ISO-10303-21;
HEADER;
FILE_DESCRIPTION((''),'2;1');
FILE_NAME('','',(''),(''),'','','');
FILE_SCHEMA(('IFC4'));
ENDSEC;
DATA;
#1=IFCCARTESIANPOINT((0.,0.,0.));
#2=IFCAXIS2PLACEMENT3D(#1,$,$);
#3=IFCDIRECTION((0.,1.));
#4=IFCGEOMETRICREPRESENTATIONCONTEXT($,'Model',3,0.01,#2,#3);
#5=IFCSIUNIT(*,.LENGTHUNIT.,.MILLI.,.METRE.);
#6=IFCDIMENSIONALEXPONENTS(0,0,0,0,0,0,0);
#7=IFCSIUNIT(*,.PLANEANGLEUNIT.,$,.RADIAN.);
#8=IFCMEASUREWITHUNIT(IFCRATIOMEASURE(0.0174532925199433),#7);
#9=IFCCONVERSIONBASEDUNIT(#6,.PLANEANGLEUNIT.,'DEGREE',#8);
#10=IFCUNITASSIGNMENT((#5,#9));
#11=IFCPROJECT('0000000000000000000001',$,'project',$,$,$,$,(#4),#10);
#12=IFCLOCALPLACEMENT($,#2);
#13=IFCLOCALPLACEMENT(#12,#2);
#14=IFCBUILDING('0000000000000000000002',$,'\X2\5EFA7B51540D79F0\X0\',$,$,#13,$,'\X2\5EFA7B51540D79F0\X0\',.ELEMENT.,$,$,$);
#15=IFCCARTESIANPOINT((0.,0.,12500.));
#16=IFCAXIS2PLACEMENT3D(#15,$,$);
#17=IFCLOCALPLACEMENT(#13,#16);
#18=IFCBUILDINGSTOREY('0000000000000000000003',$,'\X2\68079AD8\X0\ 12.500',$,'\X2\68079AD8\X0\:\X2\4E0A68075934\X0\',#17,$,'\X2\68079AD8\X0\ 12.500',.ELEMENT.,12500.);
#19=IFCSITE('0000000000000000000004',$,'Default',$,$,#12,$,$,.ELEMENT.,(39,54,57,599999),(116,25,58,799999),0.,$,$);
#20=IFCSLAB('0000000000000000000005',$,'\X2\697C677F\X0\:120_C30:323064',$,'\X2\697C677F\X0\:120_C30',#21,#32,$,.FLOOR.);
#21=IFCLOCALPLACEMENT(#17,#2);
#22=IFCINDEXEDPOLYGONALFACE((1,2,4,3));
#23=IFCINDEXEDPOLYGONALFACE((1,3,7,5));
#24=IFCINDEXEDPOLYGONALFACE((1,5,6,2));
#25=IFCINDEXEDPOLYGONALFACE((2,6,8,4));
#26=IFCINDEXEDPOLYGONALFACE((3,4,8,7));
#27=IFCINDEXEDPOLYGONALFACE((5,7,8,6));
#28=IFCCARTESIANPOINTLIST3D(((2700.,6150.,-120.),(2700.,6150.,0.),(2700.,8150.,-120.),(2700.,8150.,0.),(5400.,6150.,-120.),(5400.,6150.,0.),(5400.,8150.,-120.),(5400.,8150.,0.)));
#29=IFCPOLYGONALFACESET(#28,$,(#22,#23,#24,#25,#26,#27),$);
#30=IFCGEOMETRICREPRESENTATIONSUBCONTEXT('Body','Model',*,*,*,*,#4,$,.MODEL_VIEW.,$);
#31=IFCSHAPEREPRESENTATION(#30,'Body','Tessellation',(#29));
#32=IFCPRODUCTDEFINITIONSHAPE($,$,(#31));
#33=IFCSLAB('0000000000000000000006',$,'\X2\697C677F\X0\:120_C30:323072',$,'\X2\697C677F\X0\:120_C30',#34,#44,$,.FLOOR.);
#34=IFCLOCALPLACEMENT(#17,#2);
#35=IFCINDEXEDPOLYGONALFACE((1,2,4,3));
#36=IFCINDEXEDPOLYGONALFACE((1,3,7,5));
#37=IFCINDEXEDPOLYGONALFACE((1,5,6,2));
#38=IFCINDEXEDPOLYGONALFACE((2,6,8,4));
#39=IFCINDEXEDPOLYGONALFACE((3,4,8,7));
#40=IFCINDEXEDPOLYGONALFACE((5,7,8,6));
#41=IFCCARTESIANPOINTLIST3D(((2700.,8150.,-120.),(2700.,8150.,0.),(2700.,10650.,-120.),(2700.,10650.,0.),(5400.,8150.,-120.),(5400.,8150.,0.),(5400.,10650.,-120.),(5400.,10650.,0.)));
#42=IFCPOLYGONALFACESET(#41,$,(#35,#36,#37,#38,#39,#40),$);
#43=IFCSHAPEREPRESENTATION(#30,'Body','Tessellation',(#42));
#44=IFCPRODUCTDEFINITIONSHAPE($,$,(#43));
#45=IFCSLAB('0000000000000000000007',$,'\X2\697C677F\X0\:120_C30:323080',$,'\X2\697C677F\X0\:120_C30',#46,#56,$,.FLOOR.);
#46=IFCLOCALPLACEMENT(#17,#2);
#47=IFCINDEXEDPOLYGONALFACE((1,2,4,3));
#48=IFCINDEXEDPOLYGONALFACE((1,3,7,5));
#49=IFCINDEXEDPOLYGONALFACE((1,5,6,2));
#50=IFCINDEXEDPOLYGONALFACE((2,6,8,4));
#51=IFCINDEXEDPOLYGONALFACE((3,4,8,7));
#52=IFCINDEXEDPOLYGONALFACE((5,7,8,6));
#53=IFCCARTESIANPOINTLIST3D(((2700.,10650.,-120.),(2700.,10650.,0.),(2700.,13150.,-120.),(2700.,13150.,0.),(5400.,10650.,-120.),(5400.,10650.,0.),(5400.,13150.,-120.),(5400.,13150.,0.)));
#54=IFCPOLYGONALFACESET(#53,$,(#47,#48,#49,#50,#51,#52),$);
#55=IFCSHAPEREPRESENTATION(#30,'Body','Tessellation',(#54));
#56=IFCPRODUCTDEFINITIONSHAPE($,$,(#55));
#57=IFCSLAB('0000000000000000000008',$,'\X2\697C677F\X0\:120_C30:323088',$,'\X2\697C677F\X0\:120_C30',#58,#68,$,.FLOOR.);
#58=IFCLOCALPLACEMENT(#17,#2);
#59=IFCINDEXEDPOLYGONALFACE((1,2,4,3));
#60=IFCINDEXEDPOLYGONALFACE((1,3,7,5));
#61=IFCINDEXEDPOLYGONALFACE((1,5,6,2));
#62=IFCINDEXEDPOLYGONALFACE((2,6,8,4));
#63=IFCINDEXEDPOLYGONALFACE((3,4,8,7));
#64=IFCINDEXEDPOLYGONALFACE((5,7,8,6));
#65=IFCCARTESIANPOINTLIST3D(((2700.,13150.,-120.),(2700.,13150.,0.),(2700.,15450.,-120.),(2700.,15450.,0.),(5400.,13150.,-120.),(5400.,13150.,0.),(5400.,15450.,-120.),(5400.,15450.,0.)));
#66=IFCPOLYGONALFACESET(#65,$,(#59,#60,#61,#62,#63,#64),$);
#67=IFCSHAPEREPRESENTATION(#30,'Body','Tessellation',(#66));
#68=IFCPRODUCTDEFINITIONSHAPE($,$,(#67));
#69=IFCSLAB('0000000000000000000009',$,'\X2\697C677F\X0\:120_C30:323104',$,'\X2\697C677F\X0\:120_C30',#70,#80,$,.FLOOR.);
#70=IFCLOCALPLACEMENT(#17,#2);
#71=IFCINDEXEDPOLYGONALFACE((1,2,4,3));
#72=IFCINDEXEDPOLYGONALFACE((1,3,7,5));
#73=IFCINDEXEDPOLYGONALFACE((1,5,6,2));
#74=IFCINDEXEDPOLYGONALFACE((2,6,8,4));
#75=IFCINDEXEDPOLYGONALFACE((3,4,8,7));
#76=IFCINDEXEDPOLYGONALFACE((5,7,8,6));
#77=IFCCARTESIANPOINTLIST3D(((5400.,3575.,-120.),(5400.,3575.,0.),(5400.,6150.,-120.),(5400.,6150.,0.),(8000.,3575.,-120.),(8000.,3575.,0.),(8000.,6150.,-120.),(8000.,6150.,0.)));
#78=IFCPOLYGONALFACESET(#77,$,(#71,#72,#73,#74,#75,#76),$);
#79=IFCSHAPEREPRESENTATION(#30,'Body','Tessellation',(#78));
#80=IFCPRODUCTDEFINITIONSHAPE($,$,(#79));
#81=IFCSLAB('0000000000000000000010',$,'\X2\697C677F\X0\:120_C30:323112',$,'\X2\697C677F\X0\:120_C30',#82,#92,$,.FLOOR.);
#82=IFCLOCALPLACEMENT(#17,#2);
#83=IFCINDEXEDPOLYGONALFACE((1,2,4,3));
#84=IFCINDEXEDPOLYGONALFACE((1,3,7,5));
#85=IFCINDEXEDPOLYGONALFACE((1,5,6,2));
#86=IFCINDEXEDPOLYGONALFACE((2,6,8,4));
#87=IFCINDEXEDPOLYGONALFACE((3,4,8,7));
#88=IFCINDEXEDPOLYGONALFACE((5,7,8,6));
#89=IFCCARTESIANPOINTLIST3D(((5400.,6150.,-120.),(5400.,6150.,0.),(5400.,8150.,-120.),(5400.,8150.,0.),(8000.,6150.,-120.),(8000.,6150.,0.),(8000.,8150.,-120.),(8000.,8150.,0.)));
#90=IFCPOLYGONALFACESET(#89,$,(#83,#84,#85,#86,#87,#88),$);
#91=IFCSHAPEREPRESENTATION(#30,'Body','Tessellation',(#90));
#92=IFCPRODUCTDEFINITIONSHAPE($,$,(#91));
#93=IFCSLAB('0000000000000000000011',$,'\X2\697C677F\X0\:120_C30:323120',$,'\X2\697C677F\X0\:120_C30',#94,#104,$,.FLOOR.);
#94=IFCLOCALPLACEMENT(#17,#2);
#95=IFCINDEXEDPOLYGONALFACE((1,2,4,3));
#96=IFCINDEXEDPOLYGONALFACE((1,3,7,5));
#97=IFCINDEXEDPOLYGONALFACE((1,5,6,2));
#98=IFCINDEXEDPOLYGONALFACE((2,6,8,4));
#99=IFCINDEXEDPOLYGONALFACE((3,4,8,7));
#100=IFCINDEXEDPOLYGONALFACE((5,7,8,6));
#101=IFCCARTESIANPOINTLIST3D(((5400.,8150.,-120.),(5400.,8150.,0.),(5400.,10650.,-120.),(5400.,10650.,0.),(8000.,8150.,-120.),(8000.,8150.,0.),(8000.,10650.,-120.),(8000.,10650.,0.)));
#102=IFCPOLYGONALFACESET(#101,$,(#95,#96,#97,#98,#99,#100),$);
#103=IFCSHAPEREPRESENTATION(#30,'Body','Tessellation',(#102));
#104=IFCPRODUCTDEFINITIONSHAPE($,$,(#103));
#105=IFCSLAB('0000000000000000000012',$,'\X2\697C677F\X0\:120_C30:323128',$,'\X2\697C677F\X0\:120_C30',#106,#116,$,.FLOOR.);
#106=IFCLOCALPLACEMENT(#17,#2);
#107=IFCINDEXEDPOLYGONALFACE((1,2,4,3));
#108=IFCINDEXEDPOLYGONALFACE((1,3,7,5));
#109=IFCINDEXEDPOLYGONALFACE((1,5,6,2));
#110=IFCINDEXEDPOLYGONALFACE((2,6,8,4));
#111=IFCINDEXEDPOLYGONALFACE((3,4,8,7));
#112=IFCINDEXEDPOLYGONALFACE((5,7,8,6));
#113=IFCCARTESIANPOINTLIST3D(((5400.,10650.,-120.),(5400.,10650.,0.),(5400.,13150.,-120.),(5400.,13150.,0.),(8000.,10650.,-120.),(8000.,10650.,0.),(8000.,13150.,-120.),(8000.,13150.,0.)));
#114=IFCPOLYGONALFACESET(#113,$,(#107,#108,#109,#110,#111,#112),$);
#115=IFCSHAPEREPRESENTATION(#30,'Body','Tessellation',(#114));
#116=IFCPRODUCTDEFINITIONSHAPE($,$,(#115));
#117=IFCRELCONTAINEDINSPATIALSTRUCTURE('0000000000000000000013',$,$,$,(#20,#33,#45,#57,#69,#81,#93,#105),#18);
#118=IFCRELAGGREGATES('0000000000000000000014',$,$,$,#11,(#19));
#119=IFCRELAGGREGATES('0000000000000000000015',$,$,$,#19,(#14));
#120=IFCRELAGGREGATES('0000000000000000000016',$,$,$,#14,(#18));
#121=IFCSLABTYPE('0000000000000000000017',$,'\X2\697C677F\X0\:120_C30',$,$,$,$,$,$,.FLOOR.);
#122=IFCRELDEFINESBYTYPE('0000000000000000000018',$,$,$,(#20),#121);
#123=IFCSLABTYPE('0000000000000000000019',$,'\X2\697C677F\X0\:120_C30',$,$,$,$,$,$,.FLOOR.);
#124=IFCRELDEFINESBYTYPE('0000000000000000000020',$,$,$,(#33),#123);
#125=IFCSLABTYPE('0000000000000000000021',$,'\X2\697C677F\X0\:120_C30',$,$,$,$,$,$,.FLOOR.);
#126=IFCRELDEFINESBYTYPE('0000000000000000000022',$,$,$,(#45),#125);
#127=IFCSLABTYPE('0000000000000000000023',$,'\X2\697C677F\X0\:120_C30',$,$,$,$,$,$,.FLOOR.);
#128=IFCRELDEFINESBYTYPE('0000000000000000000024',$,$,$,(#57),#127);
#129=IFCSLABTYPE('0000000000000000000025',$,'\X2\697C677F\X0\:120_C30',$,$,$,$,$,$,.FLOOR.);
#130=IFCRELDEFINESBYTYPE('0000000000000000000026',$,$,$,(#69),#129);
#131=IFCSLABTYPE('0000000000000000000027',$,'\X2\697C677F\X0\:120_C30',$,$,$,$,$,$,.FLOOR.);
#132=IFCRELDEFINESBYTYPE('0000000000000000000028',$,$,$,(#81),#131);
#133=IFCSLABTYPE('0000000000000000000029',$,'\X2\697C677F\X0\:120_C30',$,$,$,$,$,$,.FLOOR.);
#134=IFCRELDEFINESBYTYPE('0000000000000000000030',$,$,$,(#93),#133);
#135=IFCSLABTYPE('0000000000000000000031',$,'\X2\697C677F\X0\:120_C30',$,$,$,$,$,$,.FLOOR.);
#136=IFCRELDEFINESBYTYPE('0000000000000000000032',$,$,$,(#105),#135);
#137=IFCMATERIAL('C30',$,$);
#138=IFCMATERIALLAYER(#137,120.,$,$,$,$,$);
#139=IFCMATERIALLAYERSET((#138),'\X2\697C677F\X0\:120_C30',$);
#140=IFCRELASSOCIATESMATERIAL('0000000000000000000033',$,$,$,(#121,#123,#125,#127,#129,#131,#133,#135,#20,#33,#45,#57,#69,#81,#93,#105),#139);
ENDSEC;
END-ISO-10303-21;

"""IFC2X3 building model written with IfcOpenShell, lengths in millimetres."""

from ifc_helpers import new_model, entity, si_unit, converted_unit, direction, frame, frame_2d, origin, origin_2d_with_axis, place, context, subcontext, project, spatial, rectangle, extrude, material, layer, layer_set, layer_usage, type_object, element, save


model = new_model("IFC2X3")

# Units and contexts
model_context = context("Model", 3, precision=0.01, world=origin(), true_north=direction((0.0, 1.0)))
body_context = subcontext(model_context, "Body", "Model", "MODEL_VIEW")
ifc_project = project(units=[si_unit("LENGTHUNIT", "METRE", prefix="MILLI"), converted_unit("PLANEANGLEUNIT", "DEGREE", entity("IfcRatioMeasure", 0.0174532925199433), si_unit("PLANEANGLEUNIT", "RADIAN"), dimensions=[0, 0, 0, 0, 0, 0, 0])], contexts=[model_context])

# Site, building, storey
site_placement = place(None, origin())
site = spatial("IfcSite", under=ifc_project, at=site_placement, Name="Default", CompositionType="ELEMENT", RefLatitude=(39, 54, 57, 599999), RefLongitude=(116, 25, 58, 799999), RefElevation=0.0)
building_placement = place(site_placement, origin())
building = spatial("IfcBuilding", under=site, at=building_placement, Name="建筑名称", LongName="建筑名称", CompositionType="ELEMENT")
storey_placement = place(building_placement, frame((0.0, 0.0, 12500.0)))
storey = spatial("IfcBuildingStorey", under=building, at=storey_placement, Name="标高 12.500", ObjectType="标高:上标头", LongName="标高 12.500", CompositionType="ELEMENT", Elevation=12500.0)

# Shared definitions
ifc_material = material(Name="C30")

# Slabs
ifc_layer = layer(ifc_material, 120.0)
ifc_layer_set = layer_set([ifc_layer], Name="楼板:120_C30")
ifc_layer_usage_1 = layer_usage(ifc_layer_set, "AXIS3", "POSITIVE", 0.0)
slab_type_1 = type_object("IfcSlabType", Name="楼板:120_C30", PredefinedType="FLOOR", material=ifc_layer_set)
slab_1_placement = place(storey_placement, origin())
element("IfcSlab", 1, at=slab_1_placement, inside=storey, type_object=slab_type_1, material=ifc_layer_usage_1, Name="楼板:120_C30:323064", ObjectType="楼板:120_C30", PredefinedType="FLOOR", context=body_context, shape_type="SweptSolid", body=[
    extrude(rectangle(XDim=2000.0, YDim=2700.0, at=origin_2d_with_axis()), frame((4050.0, 7150.0, 0.0), z_axis=(0.0, 0.0, -1.0), x_axis=(0.0, 1.0, 0.0)), (0.0, 0.0, 1.0), 120.0),
])
ifc_layer_usage_2 = layer_usage(ifc_layer_set, "AXIS3", "POSITIVE", 0.0)
slab_type_2 = type_object("IfcSlabType", Name="楼板:120_C30", PredefinedType="FLOOR", material=ifc_layer_set)
slab_2_placement = place(storey_placement, origin())
element("IfcSlab", 2, at=slab_2_placement, inside=storey, type_object=slab_type_2, material=ifc_layer_usage_2, Name="楼板:120_C30:323072", ObjectType="楼板:120_C30", PredefinedType="FLOOR", context=body_context, shape_type="SweptSolid", body=[
    extrude(rectangle(XDim=2500.0, YDim=2700.0, at=frame_2d((0.0, 0.0), x_axis=(1.0, 0.0))), frame((4050.0, 9400.0, 0.0), z_axis=(0.0, 0.0, -1.0), x_axis=(0.0, 1.0, 0.0)), (0.0, 0.0, 1.0), 120.0),
])
ifc_layer_usage_3 = layer_usage(ifc_layer_set, "AXIS3", "POSITIVE", 0.0)
slab_type_3 = type_object("IfcSlabType", Name="楼板:120_C30", PredefinedType="FLOOR", material=ifc_layer_set)
slab_3_placement = place(storey_placement, origin())
element("IfcSlab", 3, at=slab_3_placement, inside=storey, type_object=slab_type_3, material=ifc_layer_usage_3, Name="楼板:120_C30:323080", ObjectType="楼板:120_C30", PredefinedType="FLOOR", context=body_context, shape_type="SweptSolid", body=[
    extrude(rectangle(XDim=2500.0, YDim=2700.0, at=origin_2d_with_axis()), frame((4050.0, 11900.0, 0.0), z_axis=(0.0, 0.0, -1.0), x_axis=(0.0, 1.0, 0.0)), (0.0, 0.0, 1.0), 120.0),
])
ifc_layer_usage_4 = layer_usage(ifc_layer_set, "AXIS3", "POSITIVE", 0.0)
slab_type_4 = type_object("IfcSlabType", Name="楼板:120_C30", PredefinedType="FLOOR", material=ifc_layer_set)
slab_4_placement = place(storey_placement, origin())
element("IfcSlab", 4, at=slab_4_placement, inside=storey, type_object=slab_type_4, material=ifc_layer_usage_4, Name="楼板:120_C30:323088", ObjectType="楼板:120_C30", PredefinedType="FLOOR", context=body_context, shape_type="SweptSolid", body=[
    extrude(rectangle(XDim=2300.0, YDim=2700.0, at=origin_2d_with_axis()), frame((4050.0, 14300.0, 0.0), z_axis=(0.0, 0.0, -1.0), x_axis=(0.0, 1.0, 0.0)), (0.0, 0.0, 1.0), 120.0),
])
ifc_layer_usage_5 = layer_usage(ifc_layer_set, "AXIS3", "POSITIVE", 0.0)
slab_type_5 = type_object("IfcSlabType", Name="楼板:120_C30", PredefinedType="FLOOR", material=ifc_layer_set)
slab_5_placement = place(storey_placement, origin())
element("IfcSlab", 5, at=slab_5_placement, inside=storey, type_object=slab_type_5, material=ifc_layer_usage_5, Name="楼板:120_C30:323104", ObjectType="楼板:120_C30", PredefinedType="FLOOR", context=body_context, shape_type="SweptSolid", body=[
    extrude(rectangle(XDim=2575.0, YDim=2600.0, at=frame_2d((0.0, 0.0), x_axis=(1.0, 0.0))), frame((6700.0, 4862.5, 0.0), z_axis=(0.0, 0.0, -1.0), x_axis=(0.0, 1.0, 0.0)), (0.0, 0.0, 1.0), 120.0),
])
ifc_layer_usage_6 = layer_usage(ifc_layer_set, "AXIS3", "POSITIVE", 0.0)
slab_type_6 = type_object("IfcSlabType", Name="楼板:120_C30", PredefinedType="FLOOR", material=ifc_layer_set)
slab_6_placement = place(storey_placement, origin())
element("IfcSlab", 6, at=slab_6_placement, inside=storey, type_object=slab_type_6, material=ifc_layer_usage_6, Name="楼板:120_C30:323112", ObjectType="楼板:120_C30", PredefinedType="FLOOR", context=body_context, shape_type="SweptSolid", body=[
    extrude(rectangle(XDim=2000.0, YDim=2600.0, at=origin_2d_with_axis()), frame((6700.0, 7150.0, 0.0), z_axis=(0.0, 0.0, -1.0), x_axis=(0.0, 1.0, 0.0)), (0.0, 0.0, 1.0), 120.0),
])
ifc_layer_usage_7 = layer_usage(ifc_layer_set, "AXIS3", "POSITIVE", 0.0)
slab_type_7 = type_object("IfcSlabType", Name="楼板:120_C30", PredefinedType="FLOOR", material=ifc_layer_set)
slab_7_placement = place(storey_placement, origin())
element("IfcSlab", 7, at=slab_7_placement, inside=storey, type_object=slab_type_7, material=ifc_layer_usage_7, Name="楼板:120_C30:323120", ObjectType="楼板:120_C30", PredefinedType="FLOOR", context=body_context, shape_type="SweptSolid", body=[
    extrude(rectangle(XDim=2500.0, YDim=2600.0, at=frame_2d((0.0, 0.0), x_axis=(1.0, 0.0))), frame((6700.0, 9400.0, 0.0), z_axis=(0.0, 0.0, -1.0), x_axis=(0.0, 1.0, 0.0)), (0.0, 0.0, 1.0), 120.0),
])
ifc_layer_usage_8 = layer_usage(ifc_layer_set, "AXIS3", "POSITIVE", 0.0)
slab_type_8 = type_object("IfcSlabType", Name="楼板:120_C30", PredefinedType="FLOOR", material=ifc_layer_set)
slab_8_placement = place(storey_placement, origin())
element("IfcSlab", 8, at=slab_8_placement, inside=storey, type_object=slab_type_8, material=ifc_layer_usage_8, Name="楼板:120_C30:323128", ObjectType="楼板:120_C30", PredefinedType="FLOOR", context=body_context, shape_type="SweptSolid", body=[
    extrude(rectangle(XDim=2500.0, YDim=2600.0, at=origin_2d_with_axis()), frame((6700.0, 11900.0, 0.0), z_axis=(0.0, 0.0, -1.0), x_axis=(0.0, 1.0, 0.0)), (0.0, 0.0, 1.0), 120.0),
])

save(model, "model.ifc")
